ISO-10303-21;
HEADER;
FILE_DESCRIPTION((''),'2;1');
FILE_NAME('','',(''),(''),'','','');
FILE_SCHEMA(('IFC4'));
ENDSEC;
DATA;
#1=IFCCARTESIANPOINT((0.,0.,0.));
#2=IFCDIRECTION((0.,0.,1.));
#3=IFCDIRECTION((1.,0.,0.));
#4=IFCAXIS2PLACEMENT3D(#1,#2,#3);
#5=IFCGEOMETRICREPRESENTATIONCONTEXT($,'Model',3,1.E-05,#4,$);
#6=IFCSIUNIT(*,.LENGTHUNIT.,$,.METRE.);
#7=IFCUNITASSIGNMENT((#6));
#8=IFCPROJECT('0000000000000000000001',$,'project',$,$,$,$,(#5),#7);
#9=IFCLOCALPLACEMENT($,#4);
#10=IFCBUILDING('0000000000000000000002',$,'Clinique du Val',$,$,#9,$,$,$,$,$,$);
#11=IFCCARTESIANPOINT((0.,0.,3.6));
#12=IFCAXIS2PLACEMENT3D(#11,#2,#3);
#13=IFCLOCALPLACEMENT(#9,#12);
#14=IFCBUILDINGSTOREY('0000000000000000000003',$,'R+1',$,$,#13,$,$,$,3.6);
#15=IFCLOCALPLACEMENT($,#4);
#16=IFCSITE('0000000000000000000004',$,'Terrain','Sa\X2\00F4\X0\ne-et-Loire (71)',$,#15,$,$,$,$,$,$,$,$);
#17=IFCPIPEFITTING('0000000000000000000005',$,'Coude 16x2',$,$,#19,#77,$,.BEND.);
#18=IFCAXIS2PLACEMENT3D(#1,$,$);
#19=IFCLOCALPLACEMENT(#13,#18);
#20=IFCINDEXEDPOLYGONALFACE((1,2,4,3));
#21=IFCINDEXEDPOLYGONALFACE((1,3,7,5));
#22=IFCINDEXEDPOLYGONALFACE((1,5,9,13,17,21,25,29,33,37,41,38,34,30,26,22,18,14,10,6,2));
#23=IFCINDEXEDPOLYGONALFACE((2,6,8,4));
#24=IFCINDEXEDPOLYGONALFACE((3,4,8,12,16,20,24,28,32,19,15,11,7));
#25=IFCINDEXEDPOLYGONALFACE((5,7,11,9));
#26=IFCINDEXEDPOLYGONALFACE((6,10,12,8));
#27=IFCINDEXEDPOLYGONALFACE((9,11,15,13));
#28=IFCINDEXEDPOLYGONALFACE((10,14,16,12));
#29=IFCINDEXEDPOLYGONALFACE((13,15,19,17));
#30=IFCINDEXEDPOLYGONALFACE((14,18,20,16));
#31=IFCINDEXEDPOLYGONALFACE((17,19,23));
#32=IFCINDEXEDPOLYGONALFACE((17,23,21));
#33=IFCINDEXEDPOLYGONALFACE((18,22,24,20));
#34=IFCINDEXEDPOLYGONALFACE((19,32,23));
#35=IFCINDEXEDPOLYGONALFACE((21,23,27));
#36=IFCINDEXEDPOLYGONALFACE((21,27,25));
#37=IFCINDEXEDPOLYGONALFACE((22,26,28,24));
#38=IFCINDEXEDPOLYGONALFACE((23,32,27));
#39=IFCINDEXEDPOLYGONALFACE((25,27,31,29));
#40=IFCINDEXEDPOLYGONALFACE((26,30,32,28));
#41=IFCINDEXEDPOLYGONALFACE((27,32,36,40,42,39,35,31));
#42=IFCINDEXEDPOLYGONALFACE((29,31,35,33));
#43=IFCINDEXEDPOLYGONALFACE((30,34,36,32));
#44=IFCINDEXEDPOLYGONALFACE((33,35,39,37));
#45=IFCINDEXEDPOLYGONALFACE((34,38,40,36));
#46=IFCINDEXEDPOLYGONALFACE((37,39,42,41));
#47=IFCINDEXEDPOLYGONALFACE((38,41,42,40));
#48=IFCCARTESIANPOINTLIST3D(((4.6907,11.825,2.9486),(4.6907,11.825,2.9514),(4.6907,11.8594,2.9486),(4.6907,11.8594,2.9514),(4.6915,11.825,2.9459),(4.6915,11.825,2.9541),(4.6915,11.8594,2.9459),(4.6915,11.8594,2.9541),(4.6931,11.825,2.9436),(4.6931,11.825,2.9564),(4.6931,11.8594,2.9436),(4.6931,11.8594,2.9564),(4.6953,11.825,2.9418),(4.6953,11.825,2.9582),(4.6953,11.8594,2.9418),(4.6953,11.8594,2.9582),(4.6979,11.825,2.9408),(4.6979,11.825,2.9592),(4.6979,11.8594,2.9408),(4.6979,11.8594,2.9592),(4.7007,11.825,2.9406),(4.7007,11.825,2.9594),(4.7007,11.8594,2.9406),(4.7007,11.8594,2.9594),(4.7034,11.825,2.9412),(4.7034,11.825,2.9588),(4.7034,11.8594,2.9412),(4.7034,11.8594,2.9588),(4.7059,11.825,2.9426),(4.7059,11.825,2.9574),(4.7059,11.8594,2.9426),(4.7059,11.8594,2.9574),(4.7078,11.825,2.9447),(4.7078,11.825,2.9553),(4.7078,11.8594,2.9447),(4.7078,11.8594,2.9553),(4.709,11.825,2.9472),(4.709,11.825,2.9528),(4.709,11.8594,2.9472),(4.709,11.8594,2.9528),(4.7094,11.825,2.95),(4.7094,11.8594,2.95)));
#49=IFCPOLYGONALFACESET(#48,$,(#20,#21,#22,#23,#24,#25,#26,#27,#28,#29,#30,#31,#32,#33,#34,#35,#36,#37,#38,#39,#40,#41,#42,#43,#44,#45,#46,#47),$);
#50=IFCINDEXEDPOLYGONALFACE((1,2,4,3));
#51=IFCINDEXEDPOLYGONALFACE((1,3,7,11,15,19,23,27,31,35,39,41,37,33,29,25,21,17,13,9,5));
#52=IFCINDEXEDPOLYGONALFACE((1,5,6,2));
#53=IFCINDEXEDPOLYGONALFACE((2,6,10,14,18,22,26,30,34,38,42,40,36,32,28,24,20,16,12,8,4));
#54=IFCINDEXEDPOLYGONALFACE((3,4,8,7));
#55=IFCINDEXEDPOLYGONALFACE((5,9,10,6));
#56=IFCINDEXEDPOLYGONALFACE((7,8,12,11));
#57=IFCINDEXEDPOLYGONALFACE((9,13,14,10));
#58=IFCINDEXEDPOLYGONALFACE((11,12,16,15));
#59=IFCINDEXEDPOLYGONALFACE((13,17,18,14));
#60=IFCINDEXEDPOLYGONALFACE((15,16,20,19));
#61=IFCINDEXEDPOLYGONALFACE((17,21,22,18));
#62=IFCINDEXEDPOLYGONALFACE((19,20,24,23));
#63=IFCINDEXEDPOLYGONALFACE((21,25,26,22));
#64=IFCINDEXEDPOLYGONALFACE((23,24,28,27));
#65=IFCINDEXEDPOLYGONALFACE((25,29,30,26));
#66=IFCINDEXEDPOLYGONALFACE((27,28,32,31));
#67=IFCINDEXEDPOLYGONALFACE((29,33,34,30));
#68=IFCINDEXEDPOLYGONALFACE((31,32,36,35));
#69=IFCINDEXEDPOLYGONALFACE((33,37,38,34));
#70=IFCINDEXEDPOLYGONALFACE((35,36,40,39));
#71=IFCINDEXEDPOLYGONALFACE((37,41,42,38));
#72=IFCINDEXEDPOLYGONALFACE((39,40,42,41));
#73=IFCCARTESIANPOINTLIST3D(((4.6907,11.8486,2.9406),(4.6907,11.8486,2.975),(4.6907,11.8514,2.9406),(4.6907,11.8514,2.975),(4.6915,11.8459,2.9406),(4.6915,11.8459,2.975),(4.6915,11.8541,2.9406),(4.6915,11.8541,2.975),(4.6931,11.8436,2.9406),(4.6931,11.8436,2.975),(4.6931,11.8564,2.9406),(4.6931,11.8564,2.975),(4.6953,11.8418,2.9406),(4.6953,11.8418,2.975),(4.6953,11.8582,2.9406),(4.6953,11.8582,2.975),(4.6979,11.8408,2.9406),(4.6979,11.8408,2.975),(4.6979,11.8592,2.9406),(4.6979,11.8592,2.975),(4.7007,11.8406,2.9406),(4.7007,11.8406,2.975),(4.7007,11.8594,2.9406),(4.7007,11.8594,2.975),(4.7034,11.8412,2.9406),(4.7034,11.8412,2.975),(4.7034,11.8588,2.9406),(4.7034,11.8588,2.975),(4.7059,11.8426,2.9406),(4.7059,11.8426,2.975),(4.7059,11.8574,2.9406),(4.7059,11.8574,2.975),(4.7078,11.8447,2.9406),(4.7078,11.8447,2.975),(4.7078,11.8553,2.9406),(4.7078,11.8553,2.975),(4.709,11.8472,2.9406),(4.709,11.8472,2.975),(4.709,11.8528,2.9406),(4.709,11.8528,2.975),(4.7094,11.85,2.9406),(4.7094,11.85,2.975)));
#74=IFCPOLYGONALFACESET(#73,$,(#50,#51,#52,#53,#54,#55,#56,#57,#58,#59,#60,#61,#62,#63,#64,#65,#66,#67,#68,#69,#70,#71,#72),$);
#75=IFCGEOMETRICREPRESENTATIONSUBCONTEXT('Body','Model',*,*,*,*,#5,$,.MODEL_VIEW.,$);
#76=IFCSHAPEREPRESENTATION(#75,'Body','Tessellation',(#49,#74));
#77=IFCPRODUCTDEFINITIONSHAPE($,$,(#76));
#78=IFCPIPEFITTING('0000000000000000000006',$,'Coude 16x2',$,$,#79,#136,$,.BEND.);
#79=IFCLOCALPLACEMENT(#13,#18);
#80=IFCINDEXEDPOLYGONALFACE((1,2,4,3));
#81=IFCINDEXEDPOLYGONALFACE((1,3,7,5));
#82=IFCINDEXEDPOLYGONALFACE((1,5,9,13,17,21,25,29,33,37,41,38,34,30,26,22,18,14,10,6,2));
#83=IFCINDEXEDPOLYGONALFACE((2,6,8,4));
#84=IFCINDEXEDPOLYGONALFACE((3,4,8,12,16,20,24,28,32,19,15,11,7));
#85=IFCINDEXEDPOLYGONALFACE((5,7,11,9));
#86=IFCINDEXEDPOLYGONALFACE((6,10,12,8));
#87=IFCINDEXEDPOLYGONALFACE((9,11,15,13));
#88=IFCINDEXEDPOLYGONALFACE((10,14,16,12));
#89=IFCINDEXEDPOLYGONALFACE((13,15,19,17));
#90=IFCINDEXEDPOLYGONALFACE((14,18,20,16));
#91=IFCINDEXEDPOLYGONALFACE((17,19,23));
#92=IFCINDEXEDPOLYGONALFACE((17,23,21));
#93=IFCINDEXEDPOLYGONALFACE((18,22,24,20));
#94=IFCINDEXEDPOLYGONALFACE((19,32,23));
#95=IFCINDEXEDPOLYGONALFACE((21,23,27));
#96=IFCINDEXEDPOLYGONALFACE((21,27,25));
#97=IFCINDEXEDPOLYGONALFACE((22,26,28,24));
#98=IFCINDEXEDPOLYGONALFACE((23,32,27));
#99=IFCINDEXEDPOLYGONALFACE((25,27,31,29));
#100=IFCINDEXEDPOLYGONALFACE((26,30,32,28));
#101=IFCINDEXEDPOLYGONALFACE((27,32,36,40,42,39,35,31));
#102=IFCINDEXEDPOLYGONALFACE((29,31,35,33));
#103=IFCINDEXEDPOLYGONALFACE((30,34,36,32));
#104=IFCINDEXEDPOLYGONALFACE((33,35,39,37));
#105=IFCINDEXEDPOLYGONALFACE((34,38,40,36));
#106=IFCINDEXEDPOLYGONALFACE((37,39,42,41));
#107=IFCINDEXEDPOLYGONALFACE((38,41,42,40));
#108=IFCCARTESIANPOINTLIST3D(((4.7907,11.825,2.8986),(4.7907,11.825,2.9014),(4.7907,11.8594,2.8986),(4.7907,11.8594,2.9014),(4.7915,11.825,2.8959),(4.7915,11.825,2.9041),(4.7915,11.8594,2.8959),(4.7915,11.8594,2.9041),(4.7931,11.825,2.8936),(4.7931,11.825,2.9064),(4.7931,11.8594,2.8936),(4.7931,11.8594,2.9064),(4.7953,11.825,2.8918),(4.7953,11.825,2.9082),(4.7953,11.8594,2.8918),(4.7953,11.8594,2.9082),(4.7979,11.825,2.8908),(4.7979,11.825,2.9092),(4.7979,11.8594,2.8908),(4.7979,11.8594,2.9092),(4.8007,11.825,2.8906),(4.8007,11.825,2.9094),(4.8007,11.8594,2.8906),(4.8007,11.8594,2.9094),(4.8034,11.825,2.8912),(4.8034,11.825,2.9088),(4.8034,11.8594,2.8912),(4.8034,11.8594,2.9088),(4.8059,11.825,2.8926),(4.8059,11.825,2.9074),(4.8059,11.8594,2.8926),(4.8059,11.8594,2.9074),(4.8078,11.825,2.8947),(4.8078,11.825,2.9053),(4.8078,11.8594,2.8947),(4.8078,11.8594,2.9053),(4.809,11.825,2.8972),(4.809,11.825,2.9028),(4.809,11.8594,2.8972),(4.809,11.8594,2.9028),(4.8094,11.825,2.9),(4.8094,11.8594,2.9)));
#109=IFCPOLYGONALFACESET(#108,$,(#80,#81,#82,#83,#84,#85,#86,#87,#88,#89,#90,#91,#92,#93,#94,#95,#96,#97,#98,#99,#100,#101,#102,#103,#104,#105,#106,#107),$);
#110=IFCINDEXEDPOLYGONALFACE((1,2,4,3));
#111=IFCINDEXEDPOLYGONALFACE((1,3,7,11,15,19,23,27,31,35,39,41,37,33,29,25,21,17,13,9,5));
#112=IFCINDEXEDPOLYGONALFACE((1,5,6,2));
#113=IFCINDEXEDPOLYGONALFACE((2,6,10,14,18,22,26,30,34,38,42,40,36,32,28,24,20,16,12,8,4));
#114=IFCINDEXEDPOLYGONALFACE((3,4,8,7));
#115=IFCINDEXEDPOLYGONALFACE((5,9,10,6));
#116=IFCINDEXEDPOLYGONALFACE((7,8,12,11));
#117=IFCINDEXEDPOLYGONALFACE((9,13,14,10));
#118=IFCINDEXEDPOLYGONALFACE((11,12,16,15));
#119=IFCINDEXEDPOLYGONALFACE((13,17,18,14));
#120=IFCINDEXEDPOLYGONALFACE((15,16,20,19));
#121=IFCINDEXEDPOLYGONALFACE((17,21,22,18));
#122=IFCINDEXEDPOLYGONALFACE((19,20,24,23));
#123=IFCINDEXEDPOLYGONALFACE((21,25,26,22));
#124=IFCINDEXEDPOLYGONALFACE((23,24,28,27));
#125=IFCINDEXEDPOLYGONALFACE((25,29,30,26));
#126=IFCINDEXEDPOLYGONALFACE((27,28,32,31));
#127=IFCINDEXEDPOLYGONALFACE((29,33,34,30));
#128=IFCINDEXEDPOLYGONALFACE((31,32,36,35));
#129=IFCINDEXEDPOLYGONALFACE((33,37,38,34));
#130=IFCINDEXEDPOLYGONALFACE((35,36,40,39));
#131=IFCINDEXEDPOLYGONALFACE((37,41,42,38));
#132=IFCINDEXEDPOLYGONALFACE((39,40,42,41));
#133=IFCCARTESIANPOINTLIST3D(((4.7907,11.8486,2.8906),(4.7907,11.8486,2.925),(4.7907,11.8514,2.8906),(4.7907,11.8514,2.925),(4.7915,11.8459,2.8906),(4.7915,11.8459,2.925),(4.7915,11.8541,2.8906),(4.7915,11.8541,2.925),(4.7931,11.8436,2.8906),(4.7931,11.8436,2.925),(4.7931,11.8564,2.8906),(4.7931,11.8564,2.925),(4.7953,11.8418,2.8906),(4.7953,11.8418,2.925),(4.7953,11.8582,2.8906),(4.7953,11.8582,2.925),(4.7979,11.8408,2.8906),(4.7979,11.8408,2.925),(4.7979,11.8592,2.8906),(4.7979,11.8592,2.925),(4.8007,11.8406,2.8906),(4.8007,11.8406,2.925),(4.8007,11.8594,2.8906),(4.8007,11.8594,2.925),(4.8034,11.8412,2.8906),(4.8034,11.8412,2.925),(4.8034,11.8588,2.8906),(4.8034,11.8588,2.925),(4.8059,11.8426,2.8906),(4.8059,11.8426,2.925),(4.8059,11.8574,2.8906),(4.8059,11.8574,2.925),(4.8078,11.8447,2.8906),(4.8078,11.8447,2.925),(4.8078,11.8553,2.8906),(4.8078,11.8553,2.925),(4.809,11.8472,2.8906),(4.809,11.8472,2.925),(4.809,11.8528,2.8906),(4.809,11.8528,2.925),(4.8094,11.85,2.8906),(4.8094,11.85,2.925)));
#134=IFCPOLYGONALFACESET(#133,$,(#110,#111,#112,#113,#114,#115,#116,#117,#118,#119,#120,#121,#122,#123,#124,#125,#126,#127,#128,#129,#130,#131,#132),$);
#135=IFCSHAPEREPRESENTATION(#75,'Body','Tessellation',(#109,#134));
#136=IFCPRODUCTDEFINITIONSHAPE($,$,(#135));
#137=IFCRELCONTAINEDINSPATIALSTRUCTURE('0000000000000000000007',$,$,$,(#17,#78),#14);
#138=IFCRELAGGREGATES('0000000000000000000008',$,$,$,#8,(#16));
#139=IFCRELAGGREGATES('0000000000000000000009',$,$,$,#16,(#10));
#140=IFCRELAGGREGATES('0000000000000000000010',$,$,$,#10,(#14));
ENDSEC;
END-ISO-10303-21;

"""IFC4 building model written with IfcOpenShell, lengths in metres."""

from ifc_helpers import new_model, si_unit, frame, origin_with_axes, place, context, subcontext, project, spatial, circle, extrude, element, save


model = new_model("IFC4")

# Units and contexts
model_context = context("Model", 3, precision=1e-05, world=origin_with_axes())
body_context = subcontext(model_context, "Body", "Model", "MODEL_VIEW")
ifc_project = project(units=[si_unit("LENGTHUNIT", "METRE")], contexts=[model_context])

# Site, building, storey
site_placement = place(None, origin_with_axes())
site = spatial("IfcSite", under=ifc_project, at=site_placement, Name="Terrain", Description="Saône-et-Loire (71)")
building_placement = place(None, origin_with_axes())
building = spatial("IfcBuilding", under=site, at=building_placement, Name="Clinique du Val")
storey_placement = place(building_placement, frame((0.0, 0.0, 3.6), z_axis=(0.0, 0.0, 1.0), x_axis=(1.0, 0.0, 0.0)))
storey = spatial("IfcBuildingStorey", under=building, at=storey_placement, Name="R+1", Elevation=3.6)

# Pipe fittings
for number, where, z_axis, x_axis, name in (
    (1, (4.7, 11.85, 2.95), (0.0, 0.0, 1.0), (1.0, 0.0, 0.0), "Coude 16x2"),
    (2, (4.8, 11.85, 2.9), (0.0, 0.0, 1.0), (1.0, 0.0, 0.0), "Coude 16x2"),
):
    element("IfcPipeFitting", number, at=place(storey_placement, frame(where, z_axis=z_axis, x_axis=x_axis)), inside=storey, Name=name, PredefinedType="BEND", context=body_context, shape_type="SweptSolid", body=[
        extrude(circle(Radius=0.0094), frame((0.0, 0.0094, 0.0), z_axis=(0.0, -1.0, 0.0), x_axis=(1.0, 0.0, 0.0)), (0.0, 0.0, 1.0), 0.0344),
        extrude(circle(Radius=0.0094), frame((0.0, 0.0, -0.0094), z_axis=(0.0, 0.0, 1.0), x_axis=(1.0, 0.0, 0.0)), (0.0, 0.0, 1.0), 0.0344),
    ])

save(model, "model.ifc")
